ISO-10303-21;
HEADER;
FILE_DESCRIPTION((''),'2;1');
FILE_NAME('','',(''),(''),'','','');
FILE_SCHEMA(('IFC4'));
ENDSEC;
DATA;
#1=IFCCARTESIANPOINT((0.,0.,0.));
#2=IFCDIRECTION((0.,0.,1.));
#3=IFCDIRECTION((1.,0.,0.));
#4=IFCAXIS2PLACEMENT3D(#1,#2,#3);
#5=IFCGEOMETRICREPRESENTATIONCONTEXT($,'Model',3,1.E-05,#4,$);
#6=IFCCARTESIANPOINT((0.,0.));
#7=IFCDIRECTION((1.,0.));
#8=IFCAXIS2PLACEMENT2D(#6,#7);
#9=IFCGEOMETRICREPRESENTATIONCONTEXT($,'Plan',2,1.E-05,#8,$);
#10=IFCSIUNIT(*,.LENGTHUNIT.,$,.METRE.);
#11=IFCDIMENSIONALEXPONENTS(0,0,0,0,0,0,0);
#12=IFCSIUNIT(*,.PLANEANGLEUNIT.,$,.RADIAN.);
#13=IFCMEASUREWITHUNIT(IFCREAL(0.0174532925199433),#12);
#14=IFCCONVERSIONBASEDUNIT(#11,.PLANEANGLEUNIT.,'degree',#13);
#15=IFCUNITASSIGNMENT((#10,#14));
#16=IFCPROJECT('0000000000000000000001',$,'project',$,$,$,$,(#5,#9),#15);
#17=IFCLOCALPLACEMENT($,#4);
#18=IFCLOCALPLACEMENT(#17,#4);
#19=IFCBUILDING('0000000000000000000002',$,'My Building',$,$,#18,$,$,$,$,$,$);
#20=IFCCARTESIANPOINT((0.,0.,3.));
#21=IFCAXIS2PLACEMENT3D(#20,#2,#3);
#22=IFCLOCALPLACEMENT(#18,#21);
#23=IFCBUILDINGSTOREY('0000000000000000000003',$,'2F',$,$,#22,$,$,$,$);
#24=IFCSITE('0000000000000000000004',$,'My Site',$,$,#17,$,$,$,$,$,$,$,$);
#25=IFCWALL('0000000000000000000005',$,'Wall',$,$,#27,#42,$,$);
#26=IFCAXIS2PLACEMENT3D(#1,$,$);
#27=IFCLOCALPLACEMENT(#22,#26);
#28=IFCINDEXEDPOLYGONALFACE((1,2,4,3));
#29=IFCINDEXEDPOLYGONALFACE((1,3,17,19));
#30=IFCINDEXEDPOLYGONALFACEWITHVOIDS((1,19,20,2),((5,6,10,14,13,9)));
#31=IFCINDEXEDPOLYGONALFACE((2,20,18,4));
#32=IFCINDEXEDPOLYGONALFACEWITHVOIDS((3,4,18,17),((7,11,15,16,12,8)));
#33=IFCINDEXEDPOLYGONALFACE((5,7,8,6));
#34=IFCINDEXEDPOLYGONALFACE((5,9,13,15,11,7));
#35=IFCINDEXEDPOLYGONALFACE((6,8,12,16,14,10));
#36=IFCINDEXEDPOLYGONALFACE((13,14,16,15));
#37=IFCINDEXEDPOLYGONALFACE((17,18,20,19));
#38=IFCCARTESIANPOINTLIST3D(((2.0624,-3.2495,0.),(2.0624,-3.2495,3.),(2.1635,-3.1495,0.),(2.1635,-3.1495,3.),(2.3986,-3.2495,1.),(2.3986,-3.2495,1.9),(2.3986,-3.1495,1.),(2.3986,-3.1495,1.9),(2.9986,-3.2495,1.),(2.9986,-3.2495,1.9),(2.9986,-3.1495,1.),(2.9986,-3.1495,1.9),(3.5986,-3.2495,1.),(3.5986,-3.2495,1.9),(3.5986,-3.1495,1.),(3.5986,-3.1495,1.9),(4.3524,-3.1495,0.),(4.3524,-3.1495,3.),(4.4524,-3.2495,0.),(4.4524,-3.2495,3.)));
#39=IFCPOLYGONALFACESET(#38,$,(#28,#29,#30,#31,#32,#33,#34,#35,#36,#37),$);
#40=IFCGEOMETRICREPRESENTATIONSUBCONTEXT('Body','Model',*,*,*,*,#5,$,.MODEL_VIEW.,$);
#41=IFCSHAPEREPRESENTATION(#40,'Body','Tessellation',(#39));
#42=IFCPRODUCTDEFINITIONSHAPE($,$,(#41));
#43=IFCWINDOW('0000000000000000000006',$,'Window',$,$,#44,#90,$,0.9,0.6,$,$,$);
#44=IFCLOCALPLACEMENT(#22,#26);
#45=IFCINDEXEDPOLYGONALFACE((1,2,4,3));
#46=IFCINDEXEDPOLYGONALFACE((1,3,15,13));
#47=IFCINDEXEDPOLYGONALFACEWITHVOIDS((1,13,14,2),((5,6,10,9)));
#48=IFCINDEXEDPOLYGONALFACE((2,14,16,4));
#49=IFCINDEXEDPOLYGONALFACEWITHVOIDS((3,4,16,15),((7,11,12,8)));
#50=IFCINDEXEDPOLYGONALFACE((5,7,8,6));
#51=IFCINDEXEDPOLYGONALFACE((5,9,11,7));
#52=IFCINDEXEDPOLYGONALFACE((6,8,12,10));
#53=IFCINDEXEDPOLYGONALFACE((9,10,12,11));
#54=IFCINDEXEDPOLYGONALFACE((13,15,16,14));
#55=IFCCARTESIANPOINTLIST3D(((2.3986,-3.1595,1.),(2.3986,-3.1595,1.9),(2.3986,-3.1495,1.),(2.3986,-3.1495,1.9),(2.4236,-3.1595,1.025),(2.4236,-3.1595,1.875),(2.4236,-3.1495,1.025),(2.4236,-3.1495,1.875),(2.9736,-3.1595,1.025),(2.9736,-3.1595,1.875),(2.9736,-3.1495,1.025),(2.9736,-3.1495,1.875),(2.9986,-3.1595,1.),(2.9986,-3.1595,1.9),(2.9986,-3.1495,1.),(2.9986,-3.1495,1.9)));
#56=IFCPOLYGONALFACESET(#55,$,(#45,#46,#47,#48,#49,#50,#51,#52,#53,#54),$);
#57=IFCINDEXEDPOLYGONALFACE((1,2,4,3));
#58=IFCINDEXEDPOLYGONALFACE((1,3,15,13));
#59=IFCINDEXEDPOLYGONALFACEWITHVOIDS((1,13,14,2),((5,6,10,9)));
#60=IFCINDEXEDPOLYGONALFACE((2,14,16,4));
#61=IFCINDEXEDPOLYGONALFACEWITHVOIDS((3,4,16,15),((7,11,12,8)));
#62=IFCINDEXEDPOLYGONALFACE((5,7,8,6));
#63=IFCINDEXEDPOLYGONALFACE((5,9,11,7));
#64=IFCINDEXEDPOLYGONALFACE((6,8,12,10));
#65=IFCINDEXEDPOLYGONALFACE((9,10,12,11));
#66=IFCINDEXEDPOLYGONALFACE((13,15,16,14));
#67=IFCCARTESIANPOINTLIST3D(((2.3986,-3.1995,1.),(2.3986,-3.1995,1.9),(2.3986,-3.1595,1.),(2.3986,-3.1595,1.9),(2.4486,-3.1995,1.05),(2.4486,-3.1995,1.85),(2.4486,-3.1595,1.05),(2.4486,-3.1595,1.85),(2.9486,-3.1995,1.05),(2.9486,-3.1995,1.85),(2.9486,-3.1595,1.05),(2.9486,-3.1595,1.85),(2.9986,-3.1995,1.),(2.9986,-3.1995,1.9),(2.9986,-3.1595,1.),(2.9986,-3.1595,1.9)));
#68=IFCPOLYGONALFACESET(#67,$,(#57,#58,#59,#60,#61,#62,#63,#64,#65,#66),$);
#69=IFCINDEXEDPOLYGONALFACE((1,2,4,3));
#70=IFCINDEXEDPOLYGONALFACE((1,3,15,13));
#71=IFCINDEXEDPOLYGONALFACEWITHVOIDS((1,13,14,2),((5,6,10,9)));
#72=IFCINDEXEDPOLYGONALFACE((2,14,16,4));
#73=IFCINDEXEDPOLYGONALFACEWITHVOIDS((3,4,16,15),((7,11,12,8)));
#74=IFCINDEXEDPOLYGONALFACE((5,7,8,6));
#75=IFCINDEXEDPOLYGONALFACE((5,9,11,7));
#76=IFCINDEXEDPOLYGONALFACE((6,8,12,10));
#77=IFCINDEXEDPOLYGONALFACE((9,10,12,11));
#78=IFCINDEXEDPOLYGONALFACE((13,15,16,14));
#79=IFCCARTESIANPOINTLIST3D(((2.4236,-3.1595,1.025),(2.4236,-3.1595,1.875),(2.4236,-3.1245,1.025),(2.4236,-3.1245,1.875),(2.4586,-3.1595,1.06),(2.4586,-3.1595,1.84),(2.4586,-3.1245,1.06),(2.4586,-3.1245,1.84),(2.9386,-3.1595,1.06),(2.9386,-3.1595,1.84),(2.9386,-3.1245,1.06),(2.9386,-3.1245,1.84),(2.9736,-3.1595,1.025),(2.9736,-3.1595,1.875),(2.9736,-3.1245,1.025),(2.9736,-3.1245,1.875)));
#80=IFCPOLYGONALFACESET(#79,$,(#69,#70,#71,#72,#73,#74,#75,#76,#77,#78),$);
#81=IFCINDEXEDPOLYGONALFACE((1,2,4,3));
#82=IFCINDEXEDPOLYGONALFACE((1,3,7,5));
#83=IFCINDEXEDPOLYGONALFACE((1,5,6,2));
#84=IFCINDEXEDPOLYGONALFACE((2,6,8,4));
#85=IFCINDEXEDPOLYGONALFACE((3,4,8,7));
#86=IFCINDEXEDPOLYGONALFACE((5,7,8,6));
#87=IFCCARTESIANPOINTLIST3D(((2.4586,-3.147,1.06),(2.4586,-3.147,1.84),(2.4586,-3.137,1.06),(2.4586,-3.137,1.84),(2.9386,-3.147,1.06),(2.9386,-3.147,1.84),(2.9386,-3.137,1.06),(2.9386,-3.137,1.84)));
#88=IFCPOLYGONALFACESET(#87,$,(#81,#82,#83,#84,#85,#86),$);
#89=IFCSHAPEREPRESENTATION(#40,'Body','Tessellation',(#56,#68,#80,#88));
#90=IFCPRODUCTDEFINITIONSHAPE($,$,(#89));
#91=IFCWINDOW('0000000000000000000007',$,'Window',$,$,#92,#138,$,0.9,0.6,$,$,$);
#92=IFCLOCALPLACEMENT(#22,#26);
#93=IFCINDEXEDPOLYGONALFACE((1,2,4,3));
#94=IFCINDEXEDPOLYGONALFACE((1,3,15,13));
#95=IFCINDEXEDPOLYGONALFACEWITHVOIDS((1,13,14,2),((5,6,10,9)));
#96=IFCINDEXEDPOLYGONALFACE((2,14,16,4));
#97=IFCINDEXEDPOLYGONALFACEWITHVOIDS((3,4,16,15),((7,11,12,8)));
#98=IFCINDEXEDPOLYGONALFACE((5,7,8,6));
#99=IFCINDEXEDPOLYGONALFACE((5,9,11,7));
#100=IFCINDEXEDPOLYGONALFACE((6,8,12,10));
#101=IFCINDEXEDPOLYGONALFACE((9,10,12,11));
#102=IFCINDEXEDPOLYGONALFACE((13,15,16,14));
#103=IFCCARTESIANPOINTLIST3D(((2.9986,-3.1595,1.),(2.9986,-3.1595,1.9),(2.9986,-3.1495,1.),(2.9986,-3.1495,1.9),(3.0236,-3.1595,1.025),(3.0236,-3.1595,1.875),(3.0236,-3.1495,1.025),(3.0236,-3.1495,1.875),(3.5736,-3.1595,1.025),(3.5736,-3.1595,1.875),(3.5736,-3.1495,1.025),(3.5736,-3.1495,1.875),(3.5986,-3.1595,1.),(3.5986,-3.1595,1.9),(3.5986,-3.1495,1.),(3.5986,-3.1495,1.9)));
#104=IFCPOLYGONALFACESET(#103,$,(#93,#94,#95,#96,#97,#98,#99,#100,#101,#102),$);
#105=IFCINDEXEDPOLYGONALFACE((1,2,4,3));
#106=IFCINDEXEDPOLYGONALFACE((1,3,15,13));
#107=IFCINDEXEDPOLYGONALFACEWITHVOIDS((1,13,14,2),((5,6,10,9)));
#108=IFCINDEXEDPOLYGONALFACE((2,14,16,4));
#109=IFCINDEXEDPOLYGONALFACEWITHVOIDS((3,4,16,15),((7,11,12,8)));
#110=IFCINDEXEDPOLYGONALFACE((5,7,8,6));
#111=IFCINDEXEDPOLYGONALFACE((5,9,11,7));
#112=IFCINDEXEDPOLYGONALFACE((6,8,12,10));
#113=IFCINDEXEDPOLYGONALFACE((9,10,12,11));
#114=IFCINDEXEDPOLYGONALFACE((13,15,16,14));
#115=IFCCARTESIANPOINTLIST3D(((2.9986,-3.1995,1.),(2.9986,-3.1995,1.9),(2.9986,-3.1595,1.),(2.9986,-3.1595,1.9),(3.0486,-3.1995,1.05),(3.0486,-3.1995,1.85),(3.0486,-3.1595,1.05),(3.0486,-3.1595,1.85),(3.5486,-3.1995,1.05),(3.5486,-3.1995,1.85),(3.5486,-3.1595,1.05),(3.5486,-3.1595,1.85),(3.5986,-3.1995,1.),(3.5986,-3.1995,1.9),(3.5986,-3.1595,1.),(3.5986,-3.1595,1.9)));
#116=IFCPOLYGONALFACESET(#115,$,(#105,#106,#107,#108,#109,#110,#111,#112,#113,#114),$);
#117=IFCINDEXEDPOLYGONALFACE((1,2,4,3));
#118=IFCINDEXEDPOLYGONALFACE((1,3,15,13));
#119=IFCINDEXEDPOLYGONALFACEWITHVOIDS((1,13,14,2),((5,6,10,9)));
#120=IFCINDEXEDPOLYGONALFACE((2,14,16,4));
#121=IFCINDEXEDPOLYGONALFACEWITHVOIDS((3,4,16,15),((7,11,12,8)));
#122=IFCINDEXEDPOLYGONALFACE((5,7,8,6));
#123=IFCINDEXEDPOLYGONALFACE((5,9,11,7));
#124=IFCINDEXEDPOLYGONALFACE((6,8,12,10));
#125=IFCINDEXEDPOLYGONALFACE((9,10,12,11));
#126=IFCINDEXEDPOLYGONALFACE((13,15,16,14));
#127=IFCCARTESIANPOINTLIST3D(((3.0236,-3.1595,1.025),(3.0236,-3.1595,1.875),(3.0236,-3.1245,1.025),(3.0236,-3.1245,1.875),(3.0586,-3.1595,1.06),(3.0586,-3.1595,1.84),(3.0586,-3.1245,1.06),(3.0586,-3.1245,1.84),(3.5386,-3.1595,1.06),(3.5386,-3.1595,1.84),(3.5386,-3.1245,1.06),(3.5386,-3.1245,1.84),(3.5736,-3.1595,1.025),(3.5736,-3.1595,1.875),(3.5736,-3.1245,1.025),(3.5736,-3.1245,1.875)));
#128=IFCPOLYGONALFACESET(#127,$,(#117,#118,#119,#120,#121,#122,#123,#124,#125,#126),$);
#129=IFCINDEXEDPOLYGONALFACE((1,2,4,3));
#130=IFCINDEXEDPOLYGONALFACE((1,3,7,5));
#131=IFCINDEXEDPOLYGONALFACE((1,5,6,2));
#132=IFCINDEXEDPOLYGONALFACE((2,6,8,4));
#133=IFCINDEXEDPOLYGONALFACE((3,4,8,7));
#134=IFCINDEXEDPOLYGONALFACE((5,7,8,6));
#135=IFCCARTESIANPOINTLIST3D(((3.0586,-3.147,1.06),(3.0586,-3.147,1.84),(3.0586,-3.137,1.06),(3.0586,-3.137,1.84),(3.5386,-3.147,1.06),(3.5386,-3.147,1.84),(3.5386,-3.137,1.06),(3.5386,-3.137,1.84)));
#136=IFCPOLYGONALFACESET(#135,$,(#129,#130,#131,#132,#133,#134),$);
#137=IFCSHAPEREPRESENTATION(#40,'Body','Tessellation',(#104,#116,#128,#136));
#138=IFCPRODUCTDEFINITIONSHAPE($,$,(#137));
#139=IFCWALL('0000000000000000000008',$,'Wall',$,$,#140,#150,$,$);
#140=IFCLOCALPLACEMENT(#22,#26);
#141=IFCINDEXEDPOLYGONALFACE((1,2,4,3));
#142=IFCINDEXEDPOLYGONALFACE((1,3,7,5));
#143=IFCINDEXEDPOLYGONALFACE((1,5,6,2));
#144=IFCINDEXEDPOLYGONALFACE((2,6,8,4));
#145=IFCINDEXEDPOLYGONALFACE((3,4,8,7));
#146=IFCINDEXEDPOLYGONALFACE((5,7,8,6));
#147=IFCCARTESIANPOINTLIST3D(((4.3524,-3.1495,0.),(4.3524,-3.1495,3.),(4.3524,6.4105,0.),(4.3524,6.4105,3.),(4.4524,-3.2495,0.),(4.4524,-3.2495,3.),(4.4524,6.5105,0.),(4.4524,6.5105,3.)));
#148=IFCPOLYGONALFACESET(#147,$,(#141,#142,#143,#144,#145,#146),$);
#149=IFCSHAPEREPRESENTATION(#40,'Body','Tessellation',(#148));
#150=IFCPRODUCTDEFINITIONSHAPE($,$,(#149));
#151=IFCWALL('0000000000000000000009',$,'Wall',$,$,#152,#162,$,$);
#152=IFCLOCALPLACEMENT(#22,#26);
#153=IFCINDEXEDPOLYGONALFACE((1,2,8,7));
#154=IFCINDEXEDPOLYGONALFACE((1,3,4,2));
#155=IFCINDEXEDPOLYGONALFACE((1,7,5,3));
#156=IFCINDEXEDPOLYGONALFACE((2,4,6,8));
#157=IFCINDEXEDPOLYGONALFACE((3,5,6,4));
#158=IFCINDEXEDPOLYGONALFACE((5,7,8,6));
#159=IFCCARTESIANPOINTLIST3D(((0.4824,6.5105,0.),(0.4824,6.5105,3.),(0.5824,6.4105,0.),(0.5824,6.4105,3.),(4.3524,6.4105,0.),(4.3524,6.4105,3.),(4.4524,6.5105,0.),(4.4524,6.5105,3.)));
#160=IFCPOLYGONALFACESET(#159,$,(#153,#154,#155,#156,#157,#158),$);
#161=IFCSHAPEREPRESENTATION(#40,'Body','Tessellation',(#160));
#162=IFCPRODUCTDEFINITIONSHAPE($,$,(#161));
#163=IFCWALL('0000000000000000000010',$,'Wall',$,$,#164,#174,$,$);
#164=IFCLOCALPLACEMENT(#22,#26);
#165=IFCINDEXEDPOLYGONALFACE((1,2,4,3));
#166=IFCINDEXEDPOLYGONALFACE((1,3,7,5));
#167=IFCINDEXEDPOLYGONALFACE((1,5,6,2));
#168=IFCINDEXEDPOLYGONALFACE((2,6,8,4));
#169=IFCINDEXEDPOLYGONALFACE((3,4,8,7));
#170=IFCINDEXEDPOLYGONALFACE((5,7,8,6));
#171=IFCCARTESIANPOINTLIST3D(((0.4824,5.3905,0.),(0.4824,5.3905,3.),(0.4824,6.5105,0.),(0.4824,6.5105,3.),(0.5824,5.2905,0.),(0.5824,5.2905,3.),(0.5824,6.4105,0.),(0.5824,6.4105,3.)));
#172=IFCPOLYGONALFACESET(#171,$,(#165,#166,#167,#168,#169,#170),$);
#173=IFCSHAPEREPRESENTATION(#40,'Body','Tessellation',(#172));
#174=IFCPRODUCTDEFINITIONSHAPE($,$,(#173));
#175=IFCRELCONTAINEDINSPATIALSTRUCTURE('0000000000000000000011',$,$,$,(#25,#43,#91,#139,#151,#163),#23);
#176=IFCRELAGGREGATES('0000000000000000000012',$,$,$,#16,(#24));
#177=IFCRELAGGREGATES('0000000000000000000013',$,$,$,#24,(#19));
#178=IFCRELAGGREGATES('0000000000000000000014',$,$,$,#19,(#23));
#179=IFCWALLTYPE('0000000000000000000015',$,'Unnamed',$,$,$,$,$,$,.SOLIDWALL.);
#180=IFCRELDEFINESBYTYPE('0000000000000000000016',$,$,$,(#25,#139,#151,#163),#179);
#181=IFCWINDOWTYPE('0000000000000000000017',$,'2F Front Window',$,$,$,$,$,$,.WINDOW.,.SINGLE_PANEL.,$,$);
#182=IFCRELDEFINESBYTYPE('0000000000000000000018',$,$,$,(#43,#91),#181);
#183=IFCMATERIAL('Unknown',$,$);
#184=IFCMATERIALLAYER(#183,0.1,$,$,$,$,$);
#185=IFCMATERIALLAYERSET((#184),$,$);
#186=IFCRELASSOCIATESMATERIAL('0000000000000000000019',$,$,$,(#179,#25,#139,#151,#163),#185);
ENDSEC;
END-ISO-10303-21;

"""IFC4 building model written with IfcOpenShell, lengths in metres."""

from ifc_helpers import new_model, entity, si_unit, converted_unit, frame, origin_with_axes, origin_2d_with_axis, place, context, subcontext, project, spatial, line, indexed_curve, outline, extrude, shape, source, transform, mapped, material, layer, layer_set, layer_usage, type_object, type_shapes, element, fill, save


model = new_model("IFC4")

# Units and contexts
model_context = context("Model", 3, precision=1e-05, world=origin_with_axes())
plan_context = context("Plan", 2, precision=1e-05, world=origin_2d_with_axis())
body_context_1 = subcontext(model_context, "Body", "Model", "MODEL_VIEW")
body_context_2 = subcontext(plan_context, "Body", "Plan", "PLAN_VIEW")
ifc_project = project(units=[si_unit("LENGTHUNIT", "METRE"), converted_unit("PLANEANGLEUNIT", "degree", entity("IfcReal", 0.0174532925199433), si_unit("PLANEANGLEUNIT", "RADIAN"), dimensions=[0, 0, 0, 0, 0, 0, 0])], contexts=[model_context, plan_context])

# Site, building, storey
site_placement = place(None, origin_with_axes())
site = spatial("IfcSite", under=ifc_project, at=site_placement, Name="My Site")
building_placement = place(site_placement, origin_with_axes())
building = spatial("IfcBuilding", under=site, at=building_placement, Name="My Building")
storey_placement = place(building_placement, frame((0.0, 0.0, 3.0), z_axis=(0.0, 0.0, 1.0), x_axis=(1.0, 0.0, 0.0)))
storey = spatial("IfcBuildingStorey", under=building, at=storey_placement, Name="2F")

# Shared definitions
ifc_material = material(Name="Unknown")

# Shared definitions
ifc_layer_1 = layer(ifc_material, 0.1)
ifc_layer_set_1 = layer_set([ifc_layer_1])
wall_type = type_object("IfcWallType", Name="Unnamed", PredefinedType="SOLIDWALL", material=ifc_layer_set_1)

# Wall, openings, windows
ifc_layer_usage_1 = layer_usage(ifc_layer_set_1, "AXIS2", "POSITIVE", 0.0)
wall_1_placement = place(storey_placement, frame((2.0624, -3.2495, 0.0), z_axis=(0.0, 0.0, 1.0), x_axis=(1.0, 0.0, 0.0)))
wall_1 = element("IfcWall", 1, at=wall_1_placement, inside=storey, type_object=wall_type, material=ifc_layer_usage_1, Name="Wall", context=body_context_1, shape_type="SweptSolid", body=[
    extrude(outline(indexed_curve([(0.0, 0.0), (0.1011, 0.1), (2.29, 0.1), (2.39, 0.0)], segments=[line(1, 2, 3, 4, 1)])), origin_with_axes(), (0.0, 0.0, 1.0), 3.0),
])
shared_shape_1 = source(origin_with_axes(), body_context_1, "Body", "SweptSolid", [
    extrude(outline(indexed_curve([(0.0, 0.0), (0.6, 0.0), (0.6, 0.9), (0.0, 0.9)], segments=[line(1, 2, 3, 4, 1)])), frame((0.0, -0.6, 0.0), z_axis=(0.0, -1.0, 0.0), x_axis=(1.0, 0.0, 0.0)), (0.0, 0.0, -1.0), 1.2),
])
opening_1_placement = place(wall_1_placement, frame((0.3362, 0.0, 1.0), z_axis=(0.0, 0.0, 1.0), x_axis=(1.0, 0.0, 0.0)))
opening_1 = element("IfcOpeningElement", 2, at=opening_1_placement, cuts=wall_1, PredefinedType="OPENING", context=body_context_1, shape_type="MappedRepresentation", body=[
    mapped(shared_shape_1, transform((0.0, 0.0, 0.0), x_axis=(1.0, 0.0, 0.0), y_axis=(0.0, 1.0, 0.0), z_axis=(0.0, 0.0, 1.0), scale=1.0)),
])
opening_2_placement = place(wall_1_placement, frame((0.9362, 0.0, 1.0), z_axis=(0.0, 0.0, 1.0), x_axis=(1.0, 0.0, 0.0)))
opening_2 = element("IfcOpeningElement", 3, at=opening_2_placement, cuts=wall_1, PredefinedType="OPENING", context=body_context_1, shape_type="MappedRepresentation", body=[
    mapped(shared_shape_1, transform((0.0, 0.0, 0.0), x_axis=(1.0, 0.0, 0.0), y_axis=(0.0, 1.0, 0.0), z_axis=(0.0, 0.0, 1.0), scale=1.0)),
])
window_type_1 = type_object("IfcWindowType", Name="2F Front Window", PartitioningType="SINGLE_PANEL", PredefinedType="WINDOW")
shared_shape_2 = source(origin_with_axes(), body_context_1, "Body", "SweptSolid", [
    extrude(outline(indexed_curve([(0.0, 0.0), (0.6, 0.0), (0.6, 0.9), (0.0, 0.9)], segments=[line(1, 2, 3, 4, 1)]), holes=[indexed_curve([(0.025, 0.025), (0.575, 0.025), (0.575, 0.875), (0.025, 0.875)], segments=[line(1, 2, 3, 4, 1)])]), frame((0.0, 0.09, 0.0), z_axis=(0.0, -1.0, 0.0), x_axis=(1.0, 0.0, 0.0)), (0.0, 0.0, -1.0), 0.01),
    extrude(outline(indexed_curve([(0.0, 0.0), (0.6, 0.0), (0.6, 0.9), (0.0, 0.9)], segments=[line(1, 2, 3, 4, 1)]), holes=[indexed_curve([(0.05, 0.05), (0.55, 0.05), (0.55, 0.85), (0.05, 0.85)], segments=[line(1, 2, 3, 4, 1)])]), frame((0.0, 0.05, 0.0), z_axis=(0.0, -1.0, 0.0), x_axis=(1.0, 0.0, 0.0)), (0.0, 0.0, -1.0), 0.04),
    extrude(outline(indexed_curve([(0.0, 0.0), (0.55, 0.0), (0.55, 0.85), (0.0, 0.85)], segments=[line(1, 2, 3, 4, 1)]), holes=[indexed_curve([(0.035, 0.035), (0.515, 0.035), (0.515, 0.815), (0.035, 0.815)], segments=[line(1, 2, 3, 4, 1)])]), frame((0.025, 0.09, 0.025), z_axis=(0.0, -1.0, 0.0), x_axis=(1.0, 0.0, 0.0)), (0.0, 0.0, -1.0), 0.035),
    extrude(outline(indexed_curve([(0.035, 0.035), (0.515, 0.035), (0.515, 0.815), (0.035, 0.815)], segments=[line(1, 2, 3, 4, 1)])), frame((0.025, 0.1025, 0.025), z_axis=(0.0, -1.0, 0.0), x_axis=(1.0, 0.0, 0.0)), (0.0, 0.0, -1.0), 0.01),
])
shared_shape_3 = source(origin_with_axes(), body_context_2, "Body", "Curve2D", [
    entity("IfcIndexedPolyCurve", entity("IfcCartesianPointList2D", [[0.05, 0.05], [0.55, 0.05]])),
    entity("IfcIndexedPolyCurve", entity("IfcCartesianPointList2D", [[0.0, 0.1], [0.025, 0.1], [0.025, 0.09], [0.05, 0.09], [0.05, 0.05], [0.0, 0.05]]), [entity("IfcLineIndex", [1, 2, 3, 4, 5, 6, 1])]),
    entity("IfcIndexedPolyCurve", entity("IfcCartesianPointList2D", [[0.6, 0.1], [0.575, 0.1], [0.575, 0.09], [0.55, 0.09], [0.55, 0.05], [0.6, 0.05]]), [entity("IfcLineIndex", [1, 2, 3, 4, 5, 6, 1])]),
    entity("IfcIndexedPolyCurve", entity("IfcCartesianPointList2D", [[0.025, 0.09], [0.06, 0.09], [0.06, 0.125], [0.025, 0.125]]), [entity("IfcLineIndex", [1, 2, 3, 4, 1])]),
    entity("IfcIndexedPolyCurve", entity("IfcCartesianPointList2D", [[0.575, 0.09], [0.54, 0.09], [0.54, 0.125], [0.575, 0.125]]), [entity("IfcLineIndex", [1, 2, 3, 4, 1])]),
    entity("IfcIndexedPolyCurve", entity("IfcCartesianPointList2D", [[0.06, 0.09], [0.54, 0.09]])),
    entity("IfcIndexedPolyCurve", entity("IfcCartesianPointList2D", [[0.06, 0.125], [0.54, 0.125]])),
    entity("IfcIndexedPolyCurve", entity("IfcCartesianPointList2D", [[0.06, 0.1075], [0.54, 0.1075]])),
])
type_shapes(window_type_1, [shared_shape_2, shared_shape_3])
window_1_placement = place(opening_1_placement, origin_with_axes())
window_1 = element("IfcWindow", 4, at=window_1_placement, inside=storey, type_object=window_type_1, Name="Window", OverallHeight=0.9, OverallWidth=0.6, shapes=[
    shape(body_context_1, "Body", "MappedRepresentation", [mapped(shared_shape_2, transform((0.0, 0.0, 0.0), x_axis=(1.0, 0.0, 0.0), y_axis=(0.0, 1.0, 0.0), z_axis=(0.0, 0.0, 1.0), scale=1.0))]),
    shape(body_context_2, "Body", "MappedRepresentation", [mapped(shared_shape_3, transform((0.0, 0.0, 0.0), x_axis=(1.0, 0.0, 0.0), y_axis=(0.0, 1.0, 0.0), z_axis=(0.0, 0.0, 1.0), scale=1.0))]),
])
fill(opening_1, window_1)
window_2_placement = place(opening_2_placement, origin_with_axes())
window_2 = element("IfcWindow", 5, at=window_2_placement, inside=storey, type_object=window_type_1, Name="Window", OverallHeight=0.9, OverallWidth=0.6, shapes=[
    shape(body_context_1, "Body", "MappedRepresentation", [mapped(shared_shape_2, transform((0.0, 0.0, 0.0), x_axis=(1.0, 0.0, 0.0), y_axis=(0.0, 1.0, 0.0), z_axis=(0.0, 0.0, 1.0), scale=1.0))]),
    shape(body_context_2, "Body", "MappedRepresentation", [mapped(shared_shape_3, transform((0.0, 0.0, 0.0), x_axis=(1.0, 0.0, 0.0), y_axis=(0.0, 1.0, 0.0), z_axis=(0.0, 0.0, 1.0), scale=1.0))]),
])
fill(opening_2, window_2)

# Walls
ifc_layer_usage_2 = layer_usage(ifc_layer_set_1, "AXIS2", "POSITIVE", 0.0)
wall_2_placement = place(storey_placement, frame((4.4524, -3.2495, 0.0), z_axis=(0.0, 0.0, 1.0), x_axis=(0.0, 1.0, 0.0)))
element("IfcWall", 6, at=wall_2_placement, inside=storey, type_object=wall_type, material=ifc_layer_usage_2, Name="Wall", context=body_context_1, shape_type="SweptSolid", body=[
    extrude(outline(indexed_curve([(0.0, 0.0), (0.1, 0.1), (9.66, 0.1), (9.76, 0.0)], segments=[line(1, 2, 3, 4, 1)])), origin_with_axes(), (0.0, 0.0, 1.0), 3.0),
])
ifc_layer_usage_3 = layer_usage(ifc_layer_set_1, "AXIS2", "POSITIVE", 0.0)
wall_3_placement = place(storey_placement, frame((4.4524, 6.5105, 0.0), z_axis=(0.0, 0.0, 1.0), x_axis=(-1.0, 0.0, 0.0)))
element("IfcWall", 7, at=wall_3_placement, inside=storey, type_object=wall_type, material=ifc_layer_usage_3, Name="Wall", context=body_context_1, shape_type="SweptSolid", body=[
    extrude(outline(indexed_curve([(0.0, 0.0), (0.1, 0.1), (3.87, 0.1), (3.97, 0.0)], segments=[line(1, 2, 3, 4, 1)])), origin_with_axes(), (0.0, 0.0, 1.0), 3.0),
])
ifc_layer_usage_4 = layer_usage(ifc_layer_set_1, "AXIS2", "POSITIVE", 0.0)
wall_4_placement = place(storey_placement, frame((0.4824, 6.5105, 0.0), z_axis=(0.0, 0.0, 1.0), x_axis=(0.0, -1.0, 0.0)))
element("IfcWall", 8, at=wall_4_placement, inside=storey, type_object=wall_type, material=ifc_layer_usage_4, Name="Wall", context=body_context_1, shape_type="SweptSolid", body=[
    extrude(outline(indexed_curve([(0.0, 0.0), (0.1, 0.1), (1.22, 0.1), (1.12, 0.0)], segments=[line(1, 2, 3, 4, 1)])), origin_with_axes(), (0.0, 0.0, 1.0), 3.0),
])

save(model, "model.ifc")
